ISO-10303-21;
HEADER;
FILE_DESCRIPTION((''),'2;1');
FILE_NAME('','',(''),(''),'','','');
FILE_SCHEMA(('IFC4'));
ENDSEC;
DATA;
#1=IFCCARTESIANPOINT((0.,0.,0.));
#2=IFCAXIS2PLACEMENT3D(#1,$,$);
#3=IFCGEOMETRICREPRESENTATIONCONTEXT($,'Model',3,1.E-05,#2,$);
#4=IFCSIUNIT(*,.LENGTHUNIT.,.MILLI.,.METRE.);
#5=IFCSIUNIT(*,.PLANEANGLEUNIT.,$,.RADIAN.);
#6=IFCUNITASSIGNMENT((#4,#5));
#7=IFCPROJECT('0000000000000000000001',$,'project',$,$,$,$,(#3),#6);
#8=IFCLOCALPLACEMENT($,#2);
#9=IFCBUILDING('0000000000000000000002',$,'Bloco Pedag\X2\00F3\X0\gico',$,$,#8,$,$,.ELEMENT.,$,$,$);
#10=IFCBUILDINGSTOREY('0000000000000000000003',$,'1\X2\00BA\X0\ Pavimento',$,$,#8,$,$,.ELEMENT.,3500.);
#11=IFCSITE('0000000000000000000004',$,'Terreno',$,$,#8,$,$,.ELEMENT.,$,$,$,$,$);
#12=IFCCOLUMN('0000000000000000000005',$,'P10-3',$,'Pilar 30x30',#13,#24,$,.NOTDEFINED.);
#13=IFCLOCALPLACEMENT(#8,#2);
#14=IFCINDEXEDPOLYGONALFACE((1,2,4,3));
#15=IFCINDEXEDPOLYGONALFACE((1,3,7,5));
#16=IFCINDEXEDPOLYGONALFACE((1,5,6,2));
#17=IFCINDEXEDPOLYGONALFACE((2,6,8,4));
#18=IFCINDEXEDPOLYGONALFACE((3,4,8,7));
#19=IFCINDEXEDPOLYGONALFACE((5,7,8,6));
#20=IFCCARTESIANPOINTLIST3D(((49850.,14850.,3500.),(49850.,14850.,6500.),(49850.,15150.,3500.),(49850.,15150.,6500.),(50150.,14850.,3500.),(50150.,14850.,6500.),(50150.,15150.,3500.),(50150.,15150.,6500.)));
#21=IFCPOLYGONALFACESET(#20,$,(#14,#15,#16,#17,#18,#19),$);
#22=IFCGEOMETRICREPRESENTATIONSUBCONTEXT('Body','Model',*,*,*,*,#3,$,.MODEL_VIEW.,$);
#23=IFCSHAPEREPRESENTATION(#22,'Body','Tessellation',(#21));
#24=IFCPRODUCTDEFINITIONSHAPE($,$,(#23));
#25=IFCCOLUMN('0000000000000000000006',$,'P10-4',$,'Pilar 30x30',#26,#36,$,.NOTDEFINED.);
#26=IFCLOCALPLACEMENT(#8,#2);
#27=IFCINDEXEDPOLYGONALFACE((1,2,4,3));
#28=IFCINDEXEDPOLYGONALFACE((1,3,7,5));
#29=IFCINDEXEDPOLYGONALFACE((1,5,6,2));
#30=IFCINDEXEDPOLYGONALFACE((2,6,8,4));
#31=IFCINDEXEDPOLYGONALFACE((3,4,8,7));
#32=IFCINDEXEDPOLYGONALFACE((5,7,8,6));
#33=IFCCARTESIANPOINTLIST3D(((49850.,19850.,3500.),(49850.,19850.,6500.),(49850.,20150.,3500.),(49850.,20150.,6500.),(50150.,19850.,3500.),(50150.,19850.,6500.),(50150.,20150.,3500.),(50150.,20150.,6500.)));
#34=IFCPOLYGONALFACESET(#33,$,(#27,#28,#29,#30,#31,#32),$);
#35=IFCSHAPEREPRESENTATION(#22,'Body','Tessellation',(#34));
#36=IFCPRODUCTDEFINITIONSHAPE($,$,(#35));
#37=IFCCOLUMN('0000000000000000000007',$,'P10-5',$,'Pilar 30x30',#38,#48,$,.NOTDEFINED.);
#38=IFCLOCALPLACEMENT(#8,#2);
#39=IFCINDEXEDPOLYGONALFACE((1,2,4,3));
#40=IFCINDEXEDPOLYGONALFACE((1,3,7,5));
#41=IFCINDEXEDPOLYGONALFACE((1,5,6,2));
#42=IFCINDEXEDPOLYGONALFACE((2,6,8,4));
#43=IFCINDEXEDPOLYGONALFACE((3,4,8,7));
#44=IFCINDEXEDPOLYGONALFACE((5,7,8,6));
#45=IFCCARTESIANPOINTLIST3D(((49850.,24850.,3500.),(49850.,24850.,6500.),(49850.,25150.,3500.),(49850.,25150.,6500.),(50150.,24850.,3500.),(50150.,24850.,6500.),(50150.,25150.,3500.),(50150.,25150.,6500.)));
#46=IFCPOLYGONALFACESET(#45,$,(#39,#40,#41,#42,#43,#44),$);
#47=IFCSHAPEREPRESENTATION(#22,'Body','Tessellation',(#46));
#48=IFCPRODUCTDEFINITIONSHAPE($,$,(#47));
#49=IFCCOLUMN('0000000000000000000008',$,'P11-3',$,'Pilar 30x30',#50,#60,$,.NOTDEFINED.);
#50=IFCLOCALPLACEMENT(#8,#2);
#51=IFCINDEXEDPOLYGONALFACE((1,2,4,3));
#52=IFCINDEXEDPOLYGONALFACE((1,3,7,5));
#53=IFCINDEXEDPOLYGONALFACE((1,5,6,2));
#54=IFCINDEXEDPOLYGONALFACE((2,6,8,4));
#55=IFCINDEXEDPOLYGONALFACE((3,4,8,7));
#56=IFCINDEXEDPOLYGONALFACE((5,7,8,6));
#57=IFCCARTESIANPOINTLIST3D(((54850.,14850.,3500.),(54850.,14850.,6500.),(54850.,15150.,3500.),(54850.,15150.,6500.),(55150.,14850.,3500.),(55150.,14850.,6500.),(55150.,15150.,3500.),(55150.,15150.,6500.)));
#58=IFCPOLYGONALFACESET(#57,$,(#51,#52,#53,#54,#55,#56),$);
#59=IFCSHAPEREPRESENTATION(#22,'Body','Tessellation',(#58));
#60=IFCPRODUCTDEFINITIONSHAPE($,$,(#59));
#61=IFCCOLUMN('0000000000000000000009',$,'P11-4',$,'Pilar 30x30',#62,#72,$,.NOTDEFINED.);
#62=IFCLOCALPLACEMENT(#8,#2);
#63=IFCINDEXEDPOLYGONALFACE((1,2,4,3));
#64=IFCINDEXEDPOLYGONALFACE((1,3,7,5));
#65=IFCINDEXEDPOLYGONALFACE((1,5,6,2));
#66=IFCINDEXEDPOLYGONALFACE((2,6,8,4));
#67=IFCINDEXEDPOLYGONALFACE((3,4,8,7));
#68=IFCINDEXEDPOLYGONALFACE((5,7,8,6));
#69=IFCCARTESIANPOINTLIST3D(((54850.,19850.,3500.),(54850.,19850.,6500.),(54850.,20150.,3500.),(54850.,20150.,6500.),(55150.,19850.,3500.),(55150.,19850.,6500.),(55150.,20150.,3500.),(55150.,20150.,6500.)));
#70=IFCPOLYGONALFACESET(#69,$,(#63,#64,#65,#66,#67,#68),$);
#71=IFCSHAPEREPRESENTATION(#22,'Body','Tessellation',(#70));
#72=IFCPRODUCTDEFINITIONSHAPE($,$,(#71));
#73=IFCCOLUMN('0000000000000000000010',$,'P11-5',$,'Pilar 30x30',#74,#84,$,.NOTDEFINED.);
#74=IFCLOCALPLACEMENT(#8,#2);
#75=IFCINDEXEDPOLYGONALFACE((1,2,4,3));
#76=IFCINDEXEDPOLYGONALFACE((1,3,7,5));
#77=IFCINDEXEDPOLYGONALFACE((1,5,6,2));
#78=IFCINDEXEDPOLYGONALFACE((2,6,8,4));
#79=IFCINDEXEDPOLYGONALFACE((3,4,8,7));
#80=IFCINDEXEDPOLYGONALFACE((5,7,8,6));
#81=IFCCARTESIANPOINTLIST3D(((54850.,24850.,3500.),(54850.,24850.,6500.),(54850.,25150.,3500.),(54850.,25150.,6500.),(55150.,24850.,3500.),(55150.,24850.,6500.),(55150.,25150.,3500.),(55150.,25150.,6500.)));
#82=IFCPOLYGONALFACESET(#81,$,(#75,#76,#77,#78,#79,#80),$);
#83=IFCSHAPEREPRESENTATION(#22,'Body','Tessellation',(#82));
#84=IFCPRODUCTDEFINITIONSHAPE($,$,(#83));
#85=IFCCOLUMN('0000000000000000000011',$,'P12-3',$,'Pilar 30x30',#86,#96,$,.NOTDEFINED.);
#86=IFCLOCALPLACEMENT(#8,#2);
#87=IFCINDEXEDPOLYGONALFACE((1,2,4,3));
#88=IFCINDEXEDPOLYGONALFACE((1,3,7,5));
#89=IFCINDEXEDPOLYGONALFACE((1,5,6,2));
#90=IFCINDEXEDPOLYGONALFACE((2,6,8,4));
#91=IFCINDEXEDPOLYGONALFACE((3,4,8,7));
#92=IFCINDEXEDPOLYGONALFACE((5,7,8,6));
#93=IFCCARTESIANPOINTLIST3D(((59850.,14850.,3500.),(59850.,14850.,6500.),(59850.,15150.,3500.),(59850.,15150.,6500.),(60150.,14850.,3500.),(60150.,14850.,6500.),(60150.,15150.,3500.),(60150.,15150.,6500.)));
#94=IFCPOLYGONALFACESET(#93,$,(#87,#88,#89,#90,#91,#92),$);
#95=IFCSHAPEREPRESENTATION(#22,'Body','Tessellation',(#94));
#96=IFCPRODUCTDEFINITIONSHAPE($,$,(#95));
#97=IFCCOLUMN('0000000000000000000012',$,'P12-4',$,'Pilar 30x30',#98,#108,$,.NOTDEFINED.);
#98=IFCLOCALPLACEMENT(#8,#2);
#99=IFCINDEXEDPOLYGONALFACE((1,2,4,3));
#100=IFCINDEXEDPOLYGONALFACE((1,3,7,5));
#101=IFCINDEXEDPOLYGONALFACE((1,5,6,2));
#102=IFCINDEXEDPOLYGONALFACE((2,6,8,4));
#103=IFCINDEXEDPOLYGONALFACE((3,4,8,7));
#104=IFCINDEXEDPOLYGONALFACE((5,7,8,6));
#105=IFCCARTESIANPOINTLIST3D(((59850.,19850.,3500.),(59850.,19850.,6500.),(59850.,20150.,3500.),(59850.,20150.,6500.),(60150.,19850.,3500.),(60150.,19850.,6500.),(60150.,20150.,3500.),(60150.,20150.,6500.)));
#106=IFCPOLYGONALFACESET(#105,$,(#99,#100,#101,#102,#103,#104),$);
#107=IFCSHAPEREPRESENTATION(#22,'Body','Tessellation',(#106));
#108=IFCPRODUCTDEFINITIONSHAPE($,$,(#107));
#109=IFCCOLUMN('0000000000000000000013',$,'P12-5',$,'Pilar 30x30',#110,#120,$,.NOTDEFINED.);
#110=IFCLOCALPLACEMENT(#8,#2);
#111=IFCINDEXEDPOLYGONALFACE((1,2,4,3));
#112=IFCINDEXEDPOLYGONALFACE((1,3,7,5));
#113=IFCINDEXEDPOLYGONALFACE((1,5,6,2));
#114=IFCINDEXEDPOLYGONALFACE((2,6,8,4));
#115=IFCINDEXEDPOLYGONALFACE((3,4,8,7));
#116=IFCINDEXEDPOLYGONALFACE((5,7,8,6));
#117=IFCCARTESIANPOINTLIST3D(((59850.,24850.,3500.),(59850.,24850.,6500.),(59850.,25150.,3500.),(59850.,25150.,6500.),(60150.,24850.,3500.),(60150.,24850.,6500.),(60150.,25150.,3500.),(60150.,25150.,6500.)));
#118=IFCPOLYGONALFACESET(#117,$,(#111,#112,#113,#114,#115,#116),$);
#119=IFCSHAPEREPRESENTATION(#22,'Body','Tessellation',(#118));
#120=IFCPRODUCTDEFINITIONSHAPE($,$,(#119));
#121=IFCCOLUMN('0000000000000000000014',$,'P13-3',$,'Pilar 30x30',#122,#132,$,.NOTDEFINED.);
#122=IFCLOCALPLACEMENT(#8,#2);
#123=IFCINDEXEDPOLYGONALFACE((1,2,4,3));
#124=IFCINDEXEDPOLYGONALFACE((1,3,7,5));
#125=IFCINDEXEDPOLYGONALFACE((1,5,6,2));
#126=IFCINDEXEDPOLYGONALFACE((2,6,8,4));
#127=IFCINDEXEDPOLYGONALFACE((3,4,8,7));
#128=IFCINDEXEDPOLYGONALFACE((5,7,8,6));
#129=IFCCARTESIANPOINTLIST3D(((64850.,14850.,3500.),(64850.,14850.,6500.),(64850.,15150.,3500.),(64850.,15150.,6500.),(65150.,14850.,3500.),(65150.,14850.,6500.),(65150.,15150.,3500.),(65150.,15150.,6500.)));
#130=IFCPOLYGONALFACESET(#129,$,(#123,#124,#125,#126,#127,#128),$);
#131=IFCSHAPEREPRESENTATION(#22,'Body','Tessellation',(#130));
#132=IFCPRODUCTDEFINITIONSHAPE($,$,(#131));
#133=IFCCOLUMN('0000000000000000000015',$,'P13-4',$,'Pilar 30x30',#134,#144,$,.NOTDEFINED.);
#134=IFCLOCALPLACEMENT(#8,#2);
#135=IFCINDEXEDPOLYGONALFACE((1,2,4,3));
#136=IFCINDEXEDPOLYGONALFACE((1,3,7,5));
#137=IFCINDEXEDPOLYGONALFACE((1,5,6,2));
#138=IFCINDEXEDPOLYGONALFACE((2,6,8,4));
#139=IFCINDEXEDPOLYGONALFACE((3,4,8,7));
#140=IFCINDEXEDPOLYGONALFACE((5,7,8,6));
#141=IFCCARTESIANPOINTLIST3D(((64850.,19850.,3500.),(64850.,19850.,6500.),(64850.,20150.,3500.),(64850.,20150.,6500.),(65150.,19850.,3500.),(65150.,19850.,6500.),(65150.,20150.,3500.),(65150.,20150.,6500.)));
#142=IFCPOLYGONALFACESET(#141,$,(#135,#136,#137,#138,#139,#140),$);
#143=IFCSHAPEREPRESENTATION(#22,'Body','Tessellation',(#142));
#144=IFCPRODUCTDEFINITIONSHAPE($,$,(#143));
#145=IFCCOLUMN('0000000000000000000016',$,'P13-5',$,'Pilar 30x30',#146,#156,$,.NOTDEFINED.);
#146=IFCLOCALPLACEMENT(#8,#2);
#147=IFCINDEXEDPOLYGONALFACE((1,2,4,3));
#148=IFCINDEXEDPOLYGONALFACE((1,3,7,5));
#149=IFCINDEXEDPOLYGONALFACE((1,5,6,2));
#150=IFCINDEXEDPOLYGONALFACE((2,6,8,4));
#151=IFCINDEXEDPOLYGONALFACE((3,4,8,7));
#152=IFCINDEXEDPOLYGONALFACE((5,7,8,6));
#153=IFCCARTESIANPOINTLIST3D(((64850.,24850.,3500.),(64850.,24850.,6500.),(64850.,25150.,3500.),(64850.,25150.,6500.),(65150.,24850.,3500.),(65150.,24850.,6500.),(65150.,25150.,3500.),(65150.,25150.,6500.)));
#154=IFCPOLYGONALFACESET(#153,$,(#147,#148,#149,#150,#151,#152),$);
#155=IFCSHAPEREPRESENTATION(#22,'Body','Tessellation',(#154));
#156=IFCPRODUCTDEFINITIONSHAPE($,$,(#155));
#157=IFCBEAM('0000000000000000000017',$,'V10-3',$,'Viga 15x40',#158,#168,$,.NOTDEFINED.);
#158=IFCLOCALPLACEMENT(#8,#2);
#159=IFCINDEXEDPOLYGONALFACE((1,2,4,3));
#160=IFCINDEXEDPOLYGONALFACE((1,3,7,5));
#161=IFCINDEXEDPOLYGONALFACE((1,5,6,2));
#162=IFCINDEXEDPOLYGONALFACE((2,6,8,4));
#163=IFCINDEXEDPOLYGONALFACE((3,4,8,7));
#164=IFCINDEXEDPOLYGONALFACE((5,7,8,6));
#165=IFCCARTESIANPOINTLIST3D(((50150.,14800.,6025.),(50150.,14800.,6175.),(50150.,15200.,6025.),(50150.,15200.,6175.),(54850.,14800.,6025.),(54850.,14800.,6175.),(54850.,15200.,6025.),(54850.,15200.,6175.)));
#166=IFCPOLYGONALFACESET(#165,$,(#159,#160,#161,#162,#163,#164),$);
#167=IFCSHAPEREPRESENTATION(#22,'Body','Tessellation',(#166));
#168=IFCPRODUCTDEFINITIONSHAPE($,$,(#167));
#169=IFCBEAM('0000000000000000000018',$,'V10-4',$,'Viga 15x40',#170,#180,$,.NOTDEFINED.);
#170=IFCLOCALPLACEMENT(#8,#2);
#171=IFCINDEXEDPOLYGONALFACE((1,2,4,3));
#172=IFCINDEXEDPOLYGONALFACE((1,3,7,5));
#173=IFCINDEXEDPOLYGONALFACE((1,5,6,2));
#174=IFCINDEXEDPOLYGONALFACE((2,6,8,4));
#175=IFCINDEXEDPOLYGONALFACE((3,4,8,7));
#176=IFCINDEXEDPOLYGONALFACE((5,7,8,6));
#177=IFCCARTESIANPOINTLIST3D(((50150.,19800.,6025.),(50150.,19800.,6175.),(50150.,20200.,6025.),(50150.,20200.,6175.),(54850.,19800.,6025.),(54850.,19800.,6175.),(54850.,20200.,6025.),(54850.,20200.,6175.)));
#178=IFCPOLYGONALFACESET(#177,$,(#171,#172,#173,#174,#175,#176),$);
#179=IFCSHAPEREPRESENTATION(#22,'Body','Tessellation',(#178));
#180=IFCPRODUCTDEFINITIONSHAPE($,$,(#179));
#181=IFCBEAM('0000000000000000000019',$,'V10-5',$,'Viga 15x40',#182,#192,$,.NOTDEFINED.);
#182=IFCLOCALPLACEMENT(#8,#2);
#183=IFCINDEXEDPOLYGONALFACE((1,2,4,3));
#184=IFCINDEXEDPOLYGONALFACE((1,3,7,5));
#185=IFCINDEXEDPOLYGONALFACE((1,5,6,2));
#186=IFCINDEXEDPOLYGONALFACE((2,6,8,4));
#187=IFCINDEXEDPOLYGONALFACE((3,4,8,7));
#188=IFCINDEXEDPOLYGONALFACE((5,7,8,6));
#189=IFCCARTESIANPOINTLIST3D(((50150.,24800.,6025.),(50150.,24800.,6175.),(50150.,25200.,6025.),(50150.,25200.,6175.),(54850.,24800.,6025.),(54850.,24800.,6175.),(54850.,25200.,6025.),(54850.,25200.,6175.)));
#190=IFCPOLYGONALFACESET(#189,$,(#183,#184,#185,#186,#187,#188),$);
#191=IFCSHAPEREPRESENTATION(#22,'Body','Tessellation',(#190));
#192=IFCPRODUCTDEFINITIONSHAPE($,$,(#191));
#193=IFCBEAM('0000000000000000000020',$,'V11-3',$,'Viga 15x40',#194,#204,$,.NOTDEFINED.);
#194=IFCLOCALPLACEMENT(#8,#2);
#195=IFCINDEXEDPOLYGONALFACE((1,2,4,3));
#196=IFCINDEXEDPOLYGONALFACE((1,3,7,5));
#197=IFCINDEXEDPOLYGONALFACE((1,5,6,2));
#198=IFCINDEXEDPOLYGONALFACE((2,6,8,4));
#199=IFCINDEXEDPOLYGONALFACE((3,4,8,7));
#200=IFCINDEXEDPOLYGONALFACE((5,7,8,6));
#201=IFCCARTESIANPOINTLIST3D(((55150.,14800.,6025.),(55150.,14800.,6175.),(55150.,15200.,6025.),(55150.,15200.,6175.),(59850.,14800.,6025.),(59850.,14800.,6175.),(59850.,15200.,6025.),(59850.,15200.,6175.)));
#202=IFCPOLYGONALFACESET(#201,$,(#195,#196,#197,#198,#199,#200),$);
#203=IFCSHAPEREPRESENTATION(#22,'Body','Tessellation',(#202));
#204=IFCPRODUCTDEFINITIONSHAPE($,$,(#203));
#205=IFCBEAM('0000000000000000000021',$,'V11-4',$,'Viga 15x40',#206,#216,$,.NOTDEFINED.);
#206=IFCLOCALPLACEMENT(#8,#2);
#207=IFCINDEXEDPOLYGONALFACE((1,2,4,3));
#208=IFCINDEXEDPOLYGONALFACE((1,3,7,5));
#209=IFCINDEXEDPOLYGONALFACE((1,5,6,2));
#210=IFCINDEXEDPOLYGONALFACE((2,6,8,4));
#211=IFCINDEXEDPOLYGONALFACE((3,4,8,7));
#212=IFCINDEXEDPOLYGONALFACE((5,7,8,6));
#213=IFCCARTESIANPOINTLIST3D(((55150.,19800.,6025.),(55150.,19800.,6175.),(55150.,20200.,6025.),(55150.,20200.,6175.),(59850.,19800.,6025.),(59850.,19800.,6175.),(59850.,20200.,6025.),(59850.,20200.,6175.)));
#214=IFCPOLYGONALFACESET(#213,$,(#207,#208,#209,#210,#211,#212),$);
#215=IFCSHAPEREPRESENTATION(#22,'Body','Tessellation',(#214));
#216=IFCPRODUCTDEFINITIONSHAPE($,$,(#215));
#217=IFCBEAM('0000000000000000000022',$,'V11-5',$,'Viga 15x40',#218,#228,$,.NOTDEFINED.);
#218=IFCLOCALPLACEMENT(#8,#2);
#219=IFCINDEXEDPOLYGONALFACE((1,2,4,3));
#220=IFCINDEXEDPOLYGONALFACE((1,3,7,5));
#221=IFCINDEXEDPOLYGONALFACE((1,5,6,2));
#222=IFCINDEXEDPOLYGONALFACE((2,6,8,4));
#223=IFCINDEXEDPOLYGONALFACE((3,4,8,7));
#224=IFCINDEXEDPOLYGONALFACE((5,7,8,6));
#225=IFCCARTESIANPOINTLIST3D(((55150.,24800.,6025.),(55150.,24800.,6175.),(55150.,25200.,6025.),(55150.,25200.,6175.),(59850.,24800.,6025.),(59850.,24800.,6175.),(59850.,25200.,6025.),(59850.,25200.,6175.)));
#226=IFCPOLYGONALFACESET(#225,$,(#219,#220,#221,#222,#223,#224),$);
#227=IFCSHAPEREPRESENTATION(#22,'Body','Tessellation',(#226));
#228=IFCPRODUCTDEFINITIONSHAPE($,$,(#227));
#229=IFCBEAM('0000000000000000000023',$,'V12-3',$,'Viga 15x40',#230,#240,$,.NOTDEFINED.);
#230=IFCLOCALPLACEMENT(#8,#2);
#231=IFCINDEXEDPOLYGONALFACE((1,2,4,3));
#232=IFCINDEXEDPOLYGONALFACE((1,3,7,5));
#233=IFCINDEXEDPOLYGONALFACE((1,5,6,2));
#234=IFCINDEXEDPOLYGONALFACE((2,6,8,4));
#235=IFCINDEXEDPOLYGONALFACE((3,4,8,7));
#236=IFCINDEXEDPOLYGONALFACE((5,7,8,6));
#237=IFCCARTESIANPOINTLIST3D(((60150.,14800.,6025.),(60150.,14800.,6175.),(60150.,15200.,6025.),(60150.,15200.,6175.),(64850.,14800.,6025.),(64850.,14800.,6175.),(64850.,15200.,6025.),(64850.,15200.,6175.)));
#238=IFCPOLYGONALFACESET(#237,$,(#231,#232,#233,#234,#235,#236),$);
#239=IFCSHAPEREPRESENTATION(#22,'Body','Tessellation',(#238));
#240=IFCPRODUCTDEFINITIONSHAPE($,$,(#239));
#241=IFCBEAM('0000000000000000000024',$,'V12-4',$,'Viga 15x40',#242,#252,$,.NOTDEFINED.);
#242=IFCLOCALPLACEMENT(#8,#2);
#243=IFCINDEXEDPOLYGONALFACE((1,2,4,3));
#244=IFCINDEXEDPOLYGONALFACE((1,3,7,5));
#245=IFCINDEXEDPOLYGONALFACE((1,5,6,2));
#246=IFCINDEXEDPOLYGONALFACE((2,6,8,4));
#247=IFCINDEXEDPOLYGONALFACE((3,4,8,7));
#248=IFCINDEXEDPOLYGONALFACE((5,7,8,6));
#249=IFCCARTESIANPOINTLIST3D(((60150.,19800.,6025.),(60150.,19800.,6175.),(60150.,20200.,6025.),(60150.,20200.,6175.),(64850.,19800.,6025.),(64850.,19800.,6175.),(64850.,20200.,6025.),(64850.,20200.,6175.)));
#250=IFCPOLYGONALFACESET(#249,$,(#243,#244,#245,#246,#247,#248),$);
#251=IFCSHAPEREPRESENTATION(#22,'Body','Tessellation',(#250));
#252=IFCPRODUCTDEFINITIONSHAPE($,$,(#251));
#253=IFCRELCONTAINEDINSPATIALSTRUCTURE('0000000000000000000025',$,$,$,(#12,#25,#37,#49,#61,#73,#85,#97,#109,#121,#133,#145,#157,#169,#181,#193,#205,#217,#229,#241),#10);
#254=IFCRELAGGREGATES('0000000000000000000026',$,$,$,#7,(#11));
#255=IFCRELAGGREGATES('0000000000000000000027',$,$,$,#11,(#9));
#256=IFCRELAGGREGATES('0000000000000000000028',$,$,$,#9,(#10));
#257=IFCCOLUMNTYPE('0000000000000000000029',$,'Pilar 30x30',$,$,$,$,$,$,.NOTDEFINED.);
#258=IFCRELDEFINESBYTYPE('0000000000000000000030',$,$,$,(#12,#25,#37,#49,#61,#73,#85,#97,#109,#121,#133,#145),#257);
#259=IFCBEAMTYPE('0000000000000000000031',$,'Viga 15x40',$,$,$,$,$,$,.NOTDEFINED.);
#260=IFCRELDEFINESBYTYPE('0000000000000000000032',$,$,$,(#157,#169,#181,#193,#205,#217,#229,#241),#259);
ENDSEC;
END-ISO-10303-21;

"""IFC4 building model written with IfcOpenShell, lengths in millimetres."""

from ifc_helpers import new_model, si_unit, frame, origin, origin_2d, place, context, subcontext, project, spatial, rectangle, extrude, type_object, element, save


model = new_model("IFC4")

# Units and contexts
model_context = context("Model", 3, precision=1e-05, world=origin())
body_context = subcontext(model_context, "Body", "Model", "MODEL_VIEW")
ifc_project = project(units=[si_unit("LENGTHUNIT", "METRE", prefix="MILLI"), si_unit("PLANEANGLEUNIT", "RADIAN")], contexts=[model_context])

# Site, building, storey
placement = place(None, origin())
site = spatial("IfcSite", under=ifc_project, at=placement, Name="Terreno", CompositionType="ELEMENT")
building = spatial("IfcBuilding", under=site, at=placement, Name="Bloco Pedagógico", CompositionType="ELEMENT")
storey = spatial("IfcBuildingStorey", under=building, at=placement, Name="1º Pavimento", CompositionType="ELEMENT", Elevation=3500.0)

# Columns
column_type = type_object("IfcColumnType", Name="Pilar 30x30", PredefinedType="NOTDEFINED")
for number, where, z_axis, x_axis, name in (
    (1, (50000.0, 15000.0, 3500.0), (0.0, 0.0, 1.0), (1.0, 0.0, 0.0), "P10-3"),
    (2, (50000.0, 20000.0, 3500.0), (0.0, 0.0, 1.0), (1.0, 0.0, 0.0), "P10-4"),
    (3, (50000.0, 25000.0, 3500.0), (0.0, 0.0, 1.0), (1.0, 0.0, 0.0), "P10-5"),
    (4, (55000.0, 15000.0, 3500.0), (0.0, 0.0, 1.0), (1.0, 0.0, 0.0), "P11-3"),
    (5, (55000.0, 20000.0, 3500.0), (0.0, 0.0, 1.0), (1.0, 0.0, 0.0), "P11-4"),
    (6, (55000.0, 25000.0, 3500.0), (0.0, 0.0, 1.0), (1.0, 0.0, 0.0), "P11-5"),
    (7, (60000.0, 15000.0, 3500.0), (0.0, 0.0, 1.0), (1.0, 0.0, 0.0), "P12-3"),
    (8, (60000.0, 20000.0, 3500.0), (0.0, 0.0, 1.0), (1.0, 0.0, 0.0), "P12-4"),
    (9, (60000.0, 25000.0, 3500.0), (0.0, 0.0, 1.0), (1.0, 0.0, 0.0), "P12-5"),
    (10, (65000.0, 15000.0, 3500.0), (0.0, 0.0, 1.0), (1.0, 0.0, 0.0), "P13-3"),
    (11, (65000.0, 20000.0, 3500.0), (0.0, 0.0, 1.0), (1.0, 0.0, 0.0), "P13-4"),
    (12, (65000.0, 25000.0, 3500.0), (0.0, 0.0, 1.0), (1.0, 0.0, 0.0), "P13-5"),
):
    element("IfcColumn", number, at=place(None, frame(where, z_axis=z_axis, x_axis=x_axis)), inside=storey, type_object=column_type, Name=name, ObjectType="Pilar 30x30", PredefinedType="NOTDEFINED", context=body_context, shape_type="SweptSolid", body=[
        extrude(rectangle(XDim=300.0, YDim=300.0, at=origin_2d()), None, (0.0, 0.0, 1.0), 3000.0),
    ])

# Beams
beam_type = type_object("IfcBeamType", Name="Viga 15x40", PredefinedType="NOTDEFINED")
for number, where, z_axis, x_axis, name in (
    (13, (50150.0, 15000.0, 6100.0), (1.0, 0.0, 0.0), (0.0, 1.0, 0.0), "V10-3"),
    (14, (50150.0, 20000.0, 6100.0), (1.0, 0.0, 0.0), (0.0, 1.0, 0.0), "V10-4"),
    (15, (50150.0, 25000.0, 6100.0), (1.0, 0.0, 0.0), (0.0, 1.0, 0.0), "V10-5"),
    (16, (55150.0, 15000.0, 6100.0), (1.0, 0.0, 0.0), (0.0, 1.0, 0.0), "V11-3"),
    (17, (55150.0, 20000.0, 6100.0), (1.0, 0.0, 0.0), (0.0, 1.0, 0.0), "V11-4"),
    (18, (55150.0, 25000.0, 6100.0), (1.0, 0.0, 0.0), (0.0, 1.0, 0.0), "V11-5"),
    (19, (60150.0, 15000.0, 6100.0), (1.0, 0.0, 0.0), (0.0, 1.0, 0.0), "V12-3"),
    (20, (60150.0, 20000.0, 6100.0), (1.0, 0.0, 0.0), (0.0, 1.0, 0.0), "V12-4"),
):
    element("IfcBeam", number, at=place(None, frame(where, z_axis=z_axis, x_axis=x_axis)), inside=storey, type_object=beam_type, Name=name, ObjectType="Viga 15x40", PredefinedType="NOTDEFINED", context=body_context, shape_type="SweptSolid", body=[
        extrude(rectangle(XDim=400.0, YDim=150.0, at=origin_2d()), None, (0.0, 0.0, 1.0), 4700.0),
    ])

save(model, "model.ifc")
